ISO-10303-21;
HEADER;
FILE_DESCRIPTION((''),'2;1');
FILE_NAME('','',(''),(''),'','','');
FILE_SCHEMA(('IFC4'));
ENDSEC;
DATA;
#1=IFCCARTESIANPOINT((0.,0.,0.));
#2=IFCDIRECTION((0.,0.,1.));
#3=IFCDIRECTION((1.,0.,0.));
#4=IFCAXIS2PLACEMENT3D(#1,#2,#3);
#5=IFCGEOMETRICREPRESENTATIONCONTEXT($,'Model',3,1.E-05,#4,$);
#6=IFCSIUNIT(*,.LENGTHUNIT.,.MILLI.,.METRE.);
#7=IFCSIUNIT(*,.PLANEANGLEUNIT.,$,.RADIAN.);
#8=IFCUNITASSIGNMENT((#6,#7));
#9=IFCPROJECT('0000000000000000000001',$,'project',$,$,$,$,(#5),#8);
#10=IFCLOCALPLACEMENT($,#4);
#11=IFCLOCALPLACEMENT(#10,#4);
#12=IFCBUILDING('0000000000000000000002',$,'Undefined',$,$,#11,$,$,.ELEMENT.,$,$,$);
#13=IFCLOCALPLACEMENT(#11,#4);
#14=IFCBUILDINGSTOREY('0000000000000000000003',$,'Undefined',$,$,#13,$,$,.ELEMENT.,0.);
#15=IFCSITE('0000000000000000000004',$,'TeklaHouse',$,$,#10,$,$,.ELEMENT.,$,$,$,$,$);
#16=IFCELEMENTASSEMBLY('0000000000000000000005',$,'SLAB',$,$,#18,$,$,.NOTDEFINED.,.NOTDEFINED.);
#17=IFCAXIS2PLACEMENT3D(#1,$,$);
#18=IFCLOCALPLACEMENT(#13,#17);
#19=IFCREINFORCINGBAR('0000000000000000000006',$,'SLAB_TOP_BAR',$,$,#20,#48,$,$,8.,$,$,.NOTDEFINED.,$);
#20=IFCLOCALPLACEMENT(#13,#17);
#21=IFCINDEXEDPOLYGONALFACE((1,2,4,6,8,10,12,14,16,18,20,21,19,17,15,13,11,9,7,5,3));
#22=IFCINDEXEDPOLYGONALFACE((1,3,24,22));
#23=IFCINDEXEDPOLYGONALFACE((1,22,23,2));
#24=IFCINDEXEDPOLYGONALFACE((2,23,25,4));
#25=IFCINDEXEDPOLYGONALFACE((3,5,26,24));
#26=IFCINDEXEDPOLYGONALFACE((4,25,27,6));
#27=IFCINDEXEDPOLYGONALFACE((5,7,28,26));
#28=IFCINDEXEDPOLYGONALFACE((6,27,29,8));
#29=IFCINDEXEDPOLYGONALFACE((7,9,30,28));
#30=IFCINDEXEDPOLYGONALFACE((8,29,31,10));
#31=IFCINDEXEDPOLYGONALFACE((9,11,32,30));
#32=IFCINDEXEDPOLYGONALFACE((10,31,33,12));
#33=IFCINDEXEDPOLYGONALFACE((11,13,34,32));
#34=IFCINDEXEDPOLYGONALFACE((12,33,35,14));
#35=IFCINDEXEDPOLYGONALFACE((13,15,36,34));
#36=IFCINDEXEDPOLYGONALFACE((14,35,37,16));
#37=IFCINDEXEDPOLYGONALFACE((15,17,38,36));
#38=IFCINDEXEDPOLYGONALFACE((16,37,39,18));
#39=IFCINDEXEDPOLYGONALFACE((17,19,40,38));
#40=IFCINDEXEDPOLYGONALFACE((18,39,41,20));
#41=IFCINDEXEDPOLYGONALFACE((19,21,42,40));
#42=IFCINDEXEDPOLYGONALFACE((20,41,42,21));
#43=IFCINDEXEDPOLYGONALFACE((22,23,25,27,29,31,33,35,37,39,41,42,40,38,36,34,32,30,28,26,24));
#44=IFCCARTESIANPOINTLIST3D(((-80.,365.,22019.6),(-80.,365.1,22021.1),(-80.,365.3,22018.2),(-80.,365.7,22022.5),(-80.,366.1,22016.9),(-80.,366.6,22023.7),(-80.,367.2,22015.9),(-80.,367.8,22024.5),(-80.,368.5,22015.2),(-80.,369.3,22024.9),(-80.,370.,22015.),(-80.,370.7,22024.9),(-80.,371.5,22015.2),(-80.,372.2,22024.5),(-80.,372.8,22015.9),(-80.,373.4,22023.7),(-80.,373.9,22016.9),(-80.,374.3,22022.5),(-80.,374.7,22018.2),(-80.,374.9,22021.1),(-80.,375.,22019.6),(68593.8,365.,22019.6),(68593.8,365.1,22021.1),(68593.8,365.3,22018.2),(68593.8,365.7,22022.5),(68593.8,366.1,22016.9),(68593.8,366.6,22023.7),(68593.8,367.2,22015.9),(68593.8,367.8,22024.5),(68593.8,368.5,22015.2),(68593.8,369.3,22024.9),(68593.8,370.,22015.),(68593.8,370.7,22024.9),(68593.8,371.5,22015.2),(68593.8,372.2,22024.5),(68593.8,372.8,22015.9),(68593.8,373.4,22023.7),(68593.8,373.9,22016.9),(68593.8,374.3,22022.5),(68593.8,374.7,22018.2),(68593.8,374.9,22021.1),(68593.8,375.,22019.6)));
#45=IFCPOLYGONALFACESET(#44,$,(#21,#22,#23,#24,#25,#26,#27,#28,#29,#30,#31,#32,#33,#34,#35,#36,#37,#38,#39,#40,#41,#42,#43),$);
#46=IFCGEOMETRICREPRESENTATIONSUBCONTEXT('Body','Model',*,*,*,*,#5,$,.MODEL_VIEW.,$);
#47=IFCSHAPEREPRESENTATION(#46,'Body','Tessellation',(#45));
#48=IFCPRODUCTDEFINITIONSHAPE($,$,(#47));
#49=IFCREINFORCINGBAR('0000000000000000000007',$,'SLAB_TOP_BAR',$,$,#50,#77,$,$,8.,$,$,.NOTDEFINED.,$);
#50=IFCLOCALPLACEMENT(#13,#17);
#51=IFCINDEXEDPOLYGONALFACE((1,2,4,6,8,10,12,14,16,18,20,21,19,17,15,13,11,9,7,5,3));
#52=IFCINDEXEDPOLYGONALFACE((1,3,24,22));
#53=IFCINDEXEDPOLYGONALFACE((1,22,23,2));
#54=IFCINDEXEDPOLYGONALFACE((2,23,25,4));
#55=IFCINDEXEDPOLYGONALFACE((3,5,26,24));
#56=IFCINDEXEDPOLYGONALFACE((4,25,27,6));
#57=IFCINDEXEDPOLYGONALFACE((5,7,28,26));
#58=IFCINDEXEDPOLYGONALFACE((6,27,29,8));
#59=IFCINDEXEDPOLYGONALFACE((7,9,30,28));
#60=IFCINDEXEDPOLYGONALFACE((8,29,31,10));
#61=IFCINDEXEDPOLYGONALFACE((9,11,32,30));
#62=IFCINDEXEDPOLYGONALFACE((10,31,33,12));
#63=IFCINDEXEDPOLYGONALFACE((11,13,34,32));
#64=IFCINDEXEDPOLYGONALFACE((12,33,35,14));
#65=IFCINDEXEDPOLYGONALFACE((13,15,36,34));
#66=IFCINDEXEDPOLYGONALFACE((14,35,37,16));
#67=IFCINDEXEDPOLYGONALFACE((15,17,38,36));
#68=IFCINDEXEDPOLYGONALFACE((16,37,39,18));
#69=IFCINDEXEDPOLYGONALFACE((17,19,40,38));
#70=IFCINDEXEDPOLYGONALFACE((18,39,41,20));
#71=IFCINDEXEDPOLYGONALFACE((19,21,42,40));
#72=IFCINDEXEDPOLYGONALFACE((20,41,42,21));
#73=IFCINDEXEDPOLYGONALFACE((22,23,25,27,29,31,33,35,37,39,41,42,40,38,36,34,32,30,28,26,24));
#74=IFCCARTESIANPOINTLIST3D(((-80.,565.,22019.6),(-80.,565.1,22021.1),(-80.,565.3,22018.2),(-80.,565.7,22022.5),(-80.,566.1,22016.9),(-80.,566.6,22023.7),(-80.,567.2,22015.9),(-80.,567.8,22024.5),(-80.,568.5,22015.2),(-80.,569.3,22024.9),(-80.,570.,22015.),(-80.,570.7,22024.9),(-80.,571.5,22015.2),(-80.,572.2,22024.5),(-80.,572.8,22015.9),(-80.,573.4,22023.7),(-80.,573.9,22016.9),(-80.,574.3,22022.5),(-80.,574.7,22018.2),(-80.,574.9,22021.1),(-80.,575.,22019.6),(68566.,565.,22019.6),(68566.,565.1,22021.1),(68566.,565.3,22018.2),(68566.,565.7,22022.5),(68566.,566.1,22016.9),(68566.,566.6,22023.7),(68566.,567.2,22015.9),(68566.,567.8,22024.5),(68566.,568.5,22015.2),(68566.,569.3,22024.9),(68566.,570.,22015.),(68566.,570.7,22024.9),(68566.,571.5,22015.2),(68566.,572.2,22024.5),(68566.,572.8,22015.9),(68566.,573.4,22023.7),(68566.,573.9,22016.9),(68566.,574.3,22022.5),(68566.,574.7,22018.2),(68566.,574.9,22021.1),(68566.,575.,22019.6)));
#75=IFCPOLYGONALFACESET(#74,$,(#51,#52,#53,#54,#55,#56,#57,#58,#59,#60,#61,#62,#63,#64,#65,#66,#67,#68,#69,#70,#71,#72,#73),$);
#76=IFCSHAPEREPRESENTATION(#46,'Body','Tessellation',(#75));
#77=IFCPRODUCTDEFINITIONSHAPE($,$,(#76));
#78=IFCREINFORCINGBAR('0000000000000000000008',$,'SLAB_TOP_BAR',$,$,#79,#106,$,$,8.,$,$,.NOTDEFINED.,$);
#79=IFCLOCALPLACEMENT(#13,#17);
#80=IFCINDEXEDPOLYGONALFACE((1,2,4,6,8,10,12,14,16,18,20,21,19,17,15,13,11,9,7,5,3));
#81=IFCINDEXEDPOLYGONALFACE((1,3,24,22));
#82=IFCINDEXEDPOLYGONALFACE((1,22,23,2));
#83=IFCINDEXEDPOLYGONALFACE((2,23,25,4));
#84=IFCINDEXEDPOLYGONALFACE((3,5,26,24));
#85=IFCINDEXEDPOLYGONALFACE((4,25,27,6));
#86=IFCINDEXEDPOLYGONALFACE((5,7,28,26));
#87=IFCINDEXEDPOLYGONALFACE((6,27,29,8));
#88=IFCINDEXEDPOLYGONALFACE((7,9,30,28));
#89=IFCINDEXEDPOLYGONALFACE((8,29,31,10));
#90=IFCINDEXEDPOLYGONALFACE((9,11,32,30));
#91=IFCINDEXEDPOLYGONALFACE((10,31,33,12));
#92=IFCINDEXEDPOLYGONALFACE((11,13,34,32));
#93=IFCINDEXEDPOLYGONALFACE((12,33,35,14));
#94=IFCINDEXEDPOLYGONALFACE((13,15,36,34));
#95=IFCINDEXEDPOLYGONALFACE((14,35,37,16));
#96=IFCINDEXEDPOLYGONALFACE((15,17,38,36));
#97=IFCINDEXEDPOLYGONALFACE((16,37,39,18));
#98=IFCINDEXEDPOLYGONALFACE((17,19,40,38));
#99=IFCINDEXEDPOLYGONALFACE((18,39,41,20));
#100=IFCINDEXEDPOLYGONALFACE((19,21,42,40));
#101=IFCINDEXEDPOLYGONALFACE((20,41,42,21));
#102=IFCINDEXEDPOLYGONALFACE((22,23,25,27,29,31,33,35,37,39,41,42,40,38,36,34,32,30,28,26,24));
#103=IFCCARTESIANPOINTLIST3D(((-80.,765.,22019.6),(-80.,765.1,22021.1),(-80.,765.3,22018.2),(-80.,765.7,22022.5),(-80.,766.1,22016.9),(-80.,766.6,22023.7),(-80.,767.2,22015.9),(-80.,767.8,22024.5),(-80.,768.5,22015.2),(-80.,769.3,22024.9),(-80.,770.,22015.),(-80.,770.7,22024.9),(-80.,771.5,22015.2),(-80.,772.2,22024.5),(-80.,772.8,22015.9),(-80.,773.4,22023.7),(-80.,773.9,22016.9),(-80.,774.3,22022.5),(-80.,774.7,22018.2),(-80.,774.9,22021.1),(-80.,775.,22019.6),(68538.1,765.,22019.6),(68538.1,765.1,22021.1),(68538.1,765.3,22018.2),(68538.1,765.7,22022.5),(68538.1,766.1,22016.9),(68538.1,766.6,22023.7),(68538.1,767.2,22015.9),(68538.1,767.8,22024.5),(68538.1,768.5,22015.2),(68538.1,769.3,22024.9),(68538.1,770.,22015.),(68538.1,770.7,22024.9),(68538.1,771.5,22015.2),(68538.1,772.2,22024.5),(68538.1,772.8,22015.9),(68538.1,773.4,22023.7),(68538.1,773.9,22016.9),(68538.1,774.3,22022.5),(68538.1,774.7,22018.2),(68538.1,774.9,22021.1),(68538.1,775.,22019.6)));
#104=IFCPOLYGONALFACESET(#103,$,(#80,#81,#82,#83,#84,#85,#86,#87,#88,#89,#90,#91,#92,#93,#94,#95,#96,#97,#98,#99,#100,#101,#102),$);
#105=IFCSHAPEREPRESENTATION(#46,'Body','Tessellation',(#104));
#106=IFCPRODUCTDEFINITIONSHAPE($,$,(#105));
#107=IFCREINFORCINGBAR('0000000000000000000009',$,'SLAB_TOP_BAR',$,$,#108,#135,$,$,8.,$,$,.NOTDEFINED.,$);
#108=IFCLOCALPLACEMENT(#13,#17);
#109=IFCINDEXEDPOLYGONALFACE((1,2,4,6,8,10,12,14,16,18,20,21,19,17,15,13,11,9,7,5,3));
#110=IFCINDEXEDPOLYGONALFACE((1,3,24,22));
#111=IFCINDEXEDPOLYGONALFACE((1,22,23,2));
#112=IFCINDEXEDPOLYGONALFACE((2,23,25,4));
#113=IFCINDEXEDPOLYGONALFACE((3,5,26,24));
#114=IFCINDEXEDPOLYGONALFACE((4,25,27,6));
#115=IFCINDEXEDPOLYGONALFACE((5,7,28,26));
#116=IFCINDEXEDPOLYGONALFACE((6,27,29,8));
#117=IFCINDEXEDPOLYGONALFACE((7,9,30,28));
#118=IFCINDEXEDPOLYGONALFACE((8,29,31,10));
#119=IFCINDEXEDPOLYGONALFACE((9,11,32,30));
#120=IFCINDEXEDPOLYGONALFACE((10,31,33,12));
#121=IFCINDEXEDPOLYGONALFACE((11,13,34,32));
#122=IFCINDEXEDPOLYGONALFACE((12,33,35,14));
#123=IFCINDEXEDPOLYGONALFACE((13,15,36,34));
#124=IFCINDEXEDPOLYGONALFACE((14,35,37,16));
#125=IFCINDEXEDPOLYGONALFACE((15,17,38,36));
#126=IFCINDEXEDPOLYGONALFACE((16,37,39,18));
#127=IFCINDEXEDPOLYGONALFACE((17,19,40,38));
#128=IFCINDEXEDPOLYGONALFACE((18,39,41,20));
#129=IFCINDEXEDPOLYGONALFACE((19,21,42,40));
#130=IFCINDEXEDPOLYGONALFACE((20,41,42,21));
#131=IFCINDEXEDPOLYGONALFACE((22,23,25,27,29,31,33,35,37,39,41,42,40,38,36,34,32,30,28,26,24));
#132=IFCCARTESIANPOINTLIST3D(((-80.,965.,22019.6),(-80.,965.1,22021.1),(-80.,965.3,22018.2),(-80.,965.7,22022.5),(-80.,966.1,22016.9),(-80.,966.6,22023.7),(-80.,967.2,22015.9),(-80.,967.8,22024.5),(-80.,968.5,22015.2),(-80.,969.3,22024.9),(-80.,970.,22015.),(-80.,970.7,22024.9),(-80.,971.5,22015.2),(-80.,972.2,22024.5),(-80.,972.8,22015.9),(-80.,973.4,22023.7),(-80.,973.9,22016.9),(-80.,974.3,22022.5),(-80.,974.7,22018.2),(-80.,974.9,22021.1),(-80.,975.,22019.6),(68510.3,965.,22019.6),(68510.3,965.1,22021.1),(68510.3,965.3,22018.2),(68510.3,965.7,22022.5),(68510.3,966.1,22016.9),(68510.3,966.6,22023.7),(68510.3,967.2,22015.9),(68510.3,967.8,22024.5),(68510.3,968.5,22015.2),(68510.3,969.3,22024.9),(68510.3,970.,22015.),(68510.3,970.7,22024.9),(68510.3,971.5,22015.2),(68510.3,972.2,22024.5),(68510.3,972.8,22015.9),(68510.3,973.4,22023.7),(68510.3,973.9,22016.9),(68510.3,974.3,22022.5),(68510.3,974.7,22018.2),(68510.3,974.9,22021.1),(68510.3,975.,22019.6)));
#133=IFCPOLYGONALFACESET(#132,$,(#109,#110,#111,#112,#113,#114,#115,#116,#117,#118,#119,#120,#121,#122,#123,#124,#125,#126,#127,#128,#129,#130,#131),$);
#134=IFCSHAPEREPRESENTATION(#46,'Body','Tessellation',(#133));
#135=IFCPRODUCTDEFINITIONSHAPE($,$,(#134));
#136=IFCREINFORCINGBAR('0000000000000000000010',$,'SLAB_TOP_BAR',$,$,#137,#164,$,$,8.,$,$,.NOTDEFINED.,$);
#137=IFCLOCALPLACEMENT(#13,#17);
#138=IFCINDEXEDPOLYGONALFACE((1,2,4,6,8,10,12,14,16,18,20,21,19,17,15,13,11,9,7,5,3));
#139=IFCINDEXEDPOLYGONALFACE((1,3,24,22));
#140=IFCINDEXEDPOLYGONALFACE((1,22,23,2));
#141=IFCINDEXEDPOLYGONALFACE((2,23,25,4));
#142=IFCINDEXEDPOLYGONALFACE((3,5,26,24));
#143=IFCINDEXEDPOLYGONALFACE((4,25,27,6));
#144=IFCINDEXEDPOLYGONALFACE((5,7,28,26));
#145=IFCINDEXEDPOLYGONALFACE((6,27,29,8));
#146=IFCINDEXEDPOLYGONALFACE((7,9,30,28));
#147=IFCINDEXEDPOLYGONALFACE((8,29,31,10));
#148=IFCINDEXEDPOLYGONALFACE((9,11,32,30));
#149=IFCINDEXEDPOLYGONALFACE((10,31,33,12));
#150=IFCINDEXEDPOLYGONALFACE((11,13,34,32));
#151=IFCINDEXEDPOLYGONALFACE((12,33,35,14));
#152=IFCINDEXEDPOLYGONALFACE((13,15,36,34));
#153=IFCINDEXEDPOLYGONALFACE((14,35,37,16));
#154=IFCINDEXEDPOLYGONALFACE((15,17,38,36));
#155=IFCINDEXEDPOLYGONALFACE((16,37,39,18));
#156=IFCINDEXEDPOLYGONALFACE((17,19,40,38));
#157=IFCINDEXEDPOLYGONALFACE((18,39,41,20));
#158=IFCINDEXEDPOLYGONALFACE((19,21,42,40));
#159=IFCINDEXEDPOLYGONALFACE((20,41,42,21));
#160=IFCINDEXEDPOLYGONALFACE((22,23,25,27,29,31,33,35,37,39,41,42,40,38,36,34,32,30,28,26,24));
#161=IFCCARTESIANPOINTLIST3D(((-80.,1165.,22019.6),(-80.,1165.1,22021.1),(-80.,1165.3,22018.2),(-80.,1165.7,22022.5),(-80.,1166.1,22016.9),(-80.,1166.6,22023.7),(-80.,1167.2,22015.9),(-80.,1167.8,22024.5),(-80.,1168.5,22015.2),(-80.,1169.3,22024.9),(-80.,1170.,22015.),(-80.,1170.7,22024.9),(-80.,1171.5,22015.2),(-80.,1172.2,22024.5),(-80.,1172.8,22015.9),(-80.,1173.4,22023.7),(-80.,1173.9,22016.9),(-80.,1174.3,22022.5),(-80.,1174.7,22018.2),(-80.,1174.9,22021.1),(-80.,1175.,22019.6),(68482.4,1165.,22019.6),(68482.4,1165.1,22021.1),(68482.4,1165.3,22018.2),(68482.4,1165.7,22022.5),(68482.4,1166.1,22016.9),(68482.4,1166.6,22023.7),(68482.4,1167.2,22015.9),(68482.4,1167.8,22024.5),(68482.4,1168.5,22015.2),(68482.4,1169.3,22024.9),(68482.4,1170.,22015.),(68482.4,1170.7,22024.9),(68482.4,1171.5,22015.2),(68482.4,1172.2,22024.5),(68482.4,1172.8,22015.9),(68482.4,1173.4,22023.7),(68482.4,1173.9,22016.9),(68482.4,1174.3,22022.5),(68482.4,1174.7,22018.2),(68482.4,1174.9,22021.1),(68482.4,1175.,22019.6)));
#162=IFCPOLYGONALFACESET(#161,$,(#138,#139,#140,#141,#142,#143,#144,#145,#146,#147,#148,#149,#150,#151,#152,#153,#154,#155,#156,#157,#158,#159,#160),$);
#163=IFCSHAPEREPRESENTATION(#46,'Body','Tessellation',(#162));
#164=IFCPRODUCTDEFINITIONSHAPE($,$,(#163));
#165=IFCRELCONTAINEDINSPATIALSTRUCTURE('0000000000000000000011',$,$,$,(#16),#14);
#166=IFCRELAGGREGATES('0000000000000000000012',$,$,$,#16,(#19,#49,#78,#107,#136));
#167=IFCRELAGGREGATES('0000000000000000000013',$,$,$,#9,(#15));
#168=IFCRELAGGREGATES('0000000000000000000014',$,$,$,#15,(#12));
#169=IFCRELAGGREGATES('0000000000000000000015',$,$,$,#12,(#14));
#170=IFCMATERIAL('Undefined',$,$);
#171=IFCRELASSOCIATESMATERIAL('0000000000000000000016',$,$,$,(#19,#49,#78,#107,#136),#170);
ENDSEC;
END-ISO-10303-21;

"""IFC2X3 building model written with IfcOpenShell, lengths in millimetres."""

from ifc_helpers import new_model, entity, si_unit, frame, origin_with_axes, place, context, subcontext, project, spatial, source, transform, mapped, material, element, aggregate, save


model = new_model("IFC2X3")

# Units and contexts
model_context = context("Model", 3, precision=1e-05, world=origin_with_axes())
body_context = subcontext(model_context, "Body", "Model", "MODEL_VIEW")
ifc_project = project(units=[si_unit("LENGTHUNIT", "METRE", prefix="MILLI"), si_unit("PLANEANGLEUNIT", "RADIAN")], contexts=[model_context])

# Site, building, storey
site_placement = place(None, origin_with_axes())
site = spatial("IfcSite", under=ifc_project, at=site_placement, Name="TeklaHouse", CompositionType="ELEMENT")
building_placement = place(site_placement, origin_with_axes())
building = spatial("IfcBuilding", under=site, at=building_placement, Name="Undefined", CompositionType="ELEMENT")
storey_placement = place(building_placement, origin_with_axes())
storey = spatial("IfcBuildingStorey", under=building, at=storey_placement, Name="Undefined", CompositionType="ELEMENT", Elevation=0.0)

# Shared definitions
ifc_material_1 = material(Name="Undefined")

# Element assembly, reinforcing bars
assembly_1_placement = place(storey_placement, origin_with_axes())
assembly_1 = element("IfcElementAssembly", 1, at=assembly_1_placement, inside=storey, Name="SLAB", AssemblyPlace="NOTDEFINED", PredefinedType="NOTDEFINED")
shared_shape_1 = source(origin_with_axes(), body_context, "Body", "AdvancedSweptSolid", [
    entity("IfcSweptDiskSolid", entity("IfcTrimmedCurve", entity("IfcLine", entity("IfcCartesianPoint", [0.0, 0.0, 0.0]), entity("IfcVector", entity("IfcDirection", [1.0, 0.0, 0.0]), 1.0)), [entity("IfcParameterValue", 0.0)], [entity("IfcParameterValue", 68673.819793)], True, "PARAMETER"), 5.0, None, 0.0, 68673.8),
])
reinforcing_bar_1_placement = place(assembly_1_placement, frame((68593.8, 370.0, 22020.0), z_axis=(0.0, 0.0, -1.0), x_axis=(-1.0, 0.0, 0.0)))
reinforcing_bar_1 = element("IfcReinforcingBar", 2, at=reinforcing_bar_1_placement, material=ifc_material_1, Name="SLAB_TOP_BAR", BarRole="NOTDEFINED", NominalDiameter=8.0, context=body_context, shape_type="MappedRepresentation", body=[
    mapped(shared_shape_1, transform((0.0, 0.0, 0.0))),
])
shared_shape_2 = source(origin_with_axes(), body_context, "Body", "AdvancedSweptSolid", [
    entity("IfcSweptDiskSolid", entity("IfcTrimmedCurve", entity("IfcLine", entity("IfcCartesianPoint", [0.0, 0.0, 0.0]), entity("IfcVector", entity("IfcDirection", [1.0, 0.0, 0.0]), 1.0)), [entity("IfcParameterValue", 0.0)], [entity("IfcParameterValue", 68645.973336)], True, "PARAMETER"), 5.0, None, 0.0, 68646.0),
])
reinforcing_bar_2_placement = place(assembly_1_placement, frame((68566.0, 570.0, 22020.0), z_axis=(0.0, 0.0, -1.0), x_axis=(-1.0, 0.0, 0.0)))
reinforcing_bar_2 = element("IfcReinforcingBar", 3, at=reinforcing_bar_2_placement, material=ifc_material_1, Name="SLAB_TOP_BAR", BarRole="NOTDEFINED", NominalDiameter=8.0, context=body_context, shape_type="MappedRepresentation", body=[
    mapped(shared_shape_2, transform((0.0, 0.0, 0.0))),
])
shared_shape_3 = source(origin_with_axes(), body_context, "Body", "AdvancedSweptSolid", [
    entity("IfcSweptDiskSolid", entity("IfcTrimmedCurve", entity("IfcLine", entity("IfcCartesianPoint", [0.0, 0.0, 0.0]), entity("IfcVector", entity("IfcDirection", [1.0, 0.0, 0.0]), 1.0)), [entity("IfcParameterValue", 0.0)], [entity("IfcParameterValue", 68618.126879)], True, "PARAMETER"), 5.0, None, 0.0, 68618.1),
])
reinforcing_bar_3_placement = place(assembly_1_placement, frame((68538.1, 770.0, 22020.0), z_axis=(0.0, 0.0, -1.0), x_axis=(-1.0, 0.0, 0.0)))
reinforcing_bar_3 = element("IfcReinforcingBar", 4, at=reinforcing_bar_3_placement, material=ifc_material_1, Name="SLAB_TOP_BAR", BarRole="NOTDEFINED", NominalDiameter=8.0, context=body_context, shape_type="MappedRepresentation", body=[
    mapped(shared_shape_3, transform((0.0, 0.0, 0.0))),
])
shared_shape_4 = source(origin_with_axes(), body_context, "Body", "AdvancedSweptSolid", [
    entity("IfcSweptDiskSolid", entity("IfcTrimmedCurve", entity("IfcLine", entity("IfcCartesianPoint", [0.0, 0.0, 0.0]), entity("IfcVector", entity("IfcDirection", [1.0, 0.0, 0.0]), 1.0)), [entity("IfcParameterValue", 0.0)], [entity("IfcParameterValue", 68590.280422)], True, "PARAMETER"), 5.0, None, 0.0, 68590.3),
])
reinforcing_bar_4_placement = place(assembly_1_placement, frame((68510.3, 970.0, 22020.0), z_axis=(0.0, 0.0, -1.0), x_axis=(-1.0, 0.0, 0.0)))
reinforcing_bar_4 = element("IfcReinforcingBar", 5, at=reinforcing_bar_4_placement, material=ifc_material_1, Name="SLAB_TOP_BAR", BarRole="NOTDEFINED", NominalDiameter=8.0, context=body_context, shape_type="MappedRepresentation", body=[
    mapped(shared_shape_4, transform((0.0, 0.0, 0.0))),
])
shared_shape_5 = source(origin_with_axes(), body_context, "Body", "AdvancedSweptSolid", [
    entity("IfcSweptDiskSolid", entity("IfcTrimmedCurve", entity("IfcLine", entity("IfcCartesianPoint", [0.0, 0.0, 0.0]), entity("IfcVector", entity("IfcDirection", [1.0, 0.0, 0.0]), 1.0)), [entity("IfcParameterValue", 0.0)], [entity("IfcParameterValue", 68562.433965)], True, "PARAMETER"), 5.0, None, 0.0, 68562.4),
])
reinforcing_bar_5_placement = place(assembly_1_placement, frame((68482.4, 1170.0, 22020.0), z_axis=(0.0, 0.0, -1.0), x_axis=(-1.0, 0.0, 0.0)))
reinforcing_bar_5 = element("IfcReinforcingBar", 6, at=reinforcing_bar_5_placement, material=ifc_material_1, Name="SLAB_TOP_BAR", BarRole="NOTDEFINED", NominalDiameter=8.0, context=body_context, shape_type="MappedRepresentation", body=[
    mapped(shared_shape_5, transform((0.0, 0.0, 0.0))),
])
aggregate(assembly_1, [reinforcing_bar_1, reinforcing_bar_2, reinforcing_bar_3, reinforcing_bar_4, reinforcing_bar_5])

save(model, "model.ifc")
